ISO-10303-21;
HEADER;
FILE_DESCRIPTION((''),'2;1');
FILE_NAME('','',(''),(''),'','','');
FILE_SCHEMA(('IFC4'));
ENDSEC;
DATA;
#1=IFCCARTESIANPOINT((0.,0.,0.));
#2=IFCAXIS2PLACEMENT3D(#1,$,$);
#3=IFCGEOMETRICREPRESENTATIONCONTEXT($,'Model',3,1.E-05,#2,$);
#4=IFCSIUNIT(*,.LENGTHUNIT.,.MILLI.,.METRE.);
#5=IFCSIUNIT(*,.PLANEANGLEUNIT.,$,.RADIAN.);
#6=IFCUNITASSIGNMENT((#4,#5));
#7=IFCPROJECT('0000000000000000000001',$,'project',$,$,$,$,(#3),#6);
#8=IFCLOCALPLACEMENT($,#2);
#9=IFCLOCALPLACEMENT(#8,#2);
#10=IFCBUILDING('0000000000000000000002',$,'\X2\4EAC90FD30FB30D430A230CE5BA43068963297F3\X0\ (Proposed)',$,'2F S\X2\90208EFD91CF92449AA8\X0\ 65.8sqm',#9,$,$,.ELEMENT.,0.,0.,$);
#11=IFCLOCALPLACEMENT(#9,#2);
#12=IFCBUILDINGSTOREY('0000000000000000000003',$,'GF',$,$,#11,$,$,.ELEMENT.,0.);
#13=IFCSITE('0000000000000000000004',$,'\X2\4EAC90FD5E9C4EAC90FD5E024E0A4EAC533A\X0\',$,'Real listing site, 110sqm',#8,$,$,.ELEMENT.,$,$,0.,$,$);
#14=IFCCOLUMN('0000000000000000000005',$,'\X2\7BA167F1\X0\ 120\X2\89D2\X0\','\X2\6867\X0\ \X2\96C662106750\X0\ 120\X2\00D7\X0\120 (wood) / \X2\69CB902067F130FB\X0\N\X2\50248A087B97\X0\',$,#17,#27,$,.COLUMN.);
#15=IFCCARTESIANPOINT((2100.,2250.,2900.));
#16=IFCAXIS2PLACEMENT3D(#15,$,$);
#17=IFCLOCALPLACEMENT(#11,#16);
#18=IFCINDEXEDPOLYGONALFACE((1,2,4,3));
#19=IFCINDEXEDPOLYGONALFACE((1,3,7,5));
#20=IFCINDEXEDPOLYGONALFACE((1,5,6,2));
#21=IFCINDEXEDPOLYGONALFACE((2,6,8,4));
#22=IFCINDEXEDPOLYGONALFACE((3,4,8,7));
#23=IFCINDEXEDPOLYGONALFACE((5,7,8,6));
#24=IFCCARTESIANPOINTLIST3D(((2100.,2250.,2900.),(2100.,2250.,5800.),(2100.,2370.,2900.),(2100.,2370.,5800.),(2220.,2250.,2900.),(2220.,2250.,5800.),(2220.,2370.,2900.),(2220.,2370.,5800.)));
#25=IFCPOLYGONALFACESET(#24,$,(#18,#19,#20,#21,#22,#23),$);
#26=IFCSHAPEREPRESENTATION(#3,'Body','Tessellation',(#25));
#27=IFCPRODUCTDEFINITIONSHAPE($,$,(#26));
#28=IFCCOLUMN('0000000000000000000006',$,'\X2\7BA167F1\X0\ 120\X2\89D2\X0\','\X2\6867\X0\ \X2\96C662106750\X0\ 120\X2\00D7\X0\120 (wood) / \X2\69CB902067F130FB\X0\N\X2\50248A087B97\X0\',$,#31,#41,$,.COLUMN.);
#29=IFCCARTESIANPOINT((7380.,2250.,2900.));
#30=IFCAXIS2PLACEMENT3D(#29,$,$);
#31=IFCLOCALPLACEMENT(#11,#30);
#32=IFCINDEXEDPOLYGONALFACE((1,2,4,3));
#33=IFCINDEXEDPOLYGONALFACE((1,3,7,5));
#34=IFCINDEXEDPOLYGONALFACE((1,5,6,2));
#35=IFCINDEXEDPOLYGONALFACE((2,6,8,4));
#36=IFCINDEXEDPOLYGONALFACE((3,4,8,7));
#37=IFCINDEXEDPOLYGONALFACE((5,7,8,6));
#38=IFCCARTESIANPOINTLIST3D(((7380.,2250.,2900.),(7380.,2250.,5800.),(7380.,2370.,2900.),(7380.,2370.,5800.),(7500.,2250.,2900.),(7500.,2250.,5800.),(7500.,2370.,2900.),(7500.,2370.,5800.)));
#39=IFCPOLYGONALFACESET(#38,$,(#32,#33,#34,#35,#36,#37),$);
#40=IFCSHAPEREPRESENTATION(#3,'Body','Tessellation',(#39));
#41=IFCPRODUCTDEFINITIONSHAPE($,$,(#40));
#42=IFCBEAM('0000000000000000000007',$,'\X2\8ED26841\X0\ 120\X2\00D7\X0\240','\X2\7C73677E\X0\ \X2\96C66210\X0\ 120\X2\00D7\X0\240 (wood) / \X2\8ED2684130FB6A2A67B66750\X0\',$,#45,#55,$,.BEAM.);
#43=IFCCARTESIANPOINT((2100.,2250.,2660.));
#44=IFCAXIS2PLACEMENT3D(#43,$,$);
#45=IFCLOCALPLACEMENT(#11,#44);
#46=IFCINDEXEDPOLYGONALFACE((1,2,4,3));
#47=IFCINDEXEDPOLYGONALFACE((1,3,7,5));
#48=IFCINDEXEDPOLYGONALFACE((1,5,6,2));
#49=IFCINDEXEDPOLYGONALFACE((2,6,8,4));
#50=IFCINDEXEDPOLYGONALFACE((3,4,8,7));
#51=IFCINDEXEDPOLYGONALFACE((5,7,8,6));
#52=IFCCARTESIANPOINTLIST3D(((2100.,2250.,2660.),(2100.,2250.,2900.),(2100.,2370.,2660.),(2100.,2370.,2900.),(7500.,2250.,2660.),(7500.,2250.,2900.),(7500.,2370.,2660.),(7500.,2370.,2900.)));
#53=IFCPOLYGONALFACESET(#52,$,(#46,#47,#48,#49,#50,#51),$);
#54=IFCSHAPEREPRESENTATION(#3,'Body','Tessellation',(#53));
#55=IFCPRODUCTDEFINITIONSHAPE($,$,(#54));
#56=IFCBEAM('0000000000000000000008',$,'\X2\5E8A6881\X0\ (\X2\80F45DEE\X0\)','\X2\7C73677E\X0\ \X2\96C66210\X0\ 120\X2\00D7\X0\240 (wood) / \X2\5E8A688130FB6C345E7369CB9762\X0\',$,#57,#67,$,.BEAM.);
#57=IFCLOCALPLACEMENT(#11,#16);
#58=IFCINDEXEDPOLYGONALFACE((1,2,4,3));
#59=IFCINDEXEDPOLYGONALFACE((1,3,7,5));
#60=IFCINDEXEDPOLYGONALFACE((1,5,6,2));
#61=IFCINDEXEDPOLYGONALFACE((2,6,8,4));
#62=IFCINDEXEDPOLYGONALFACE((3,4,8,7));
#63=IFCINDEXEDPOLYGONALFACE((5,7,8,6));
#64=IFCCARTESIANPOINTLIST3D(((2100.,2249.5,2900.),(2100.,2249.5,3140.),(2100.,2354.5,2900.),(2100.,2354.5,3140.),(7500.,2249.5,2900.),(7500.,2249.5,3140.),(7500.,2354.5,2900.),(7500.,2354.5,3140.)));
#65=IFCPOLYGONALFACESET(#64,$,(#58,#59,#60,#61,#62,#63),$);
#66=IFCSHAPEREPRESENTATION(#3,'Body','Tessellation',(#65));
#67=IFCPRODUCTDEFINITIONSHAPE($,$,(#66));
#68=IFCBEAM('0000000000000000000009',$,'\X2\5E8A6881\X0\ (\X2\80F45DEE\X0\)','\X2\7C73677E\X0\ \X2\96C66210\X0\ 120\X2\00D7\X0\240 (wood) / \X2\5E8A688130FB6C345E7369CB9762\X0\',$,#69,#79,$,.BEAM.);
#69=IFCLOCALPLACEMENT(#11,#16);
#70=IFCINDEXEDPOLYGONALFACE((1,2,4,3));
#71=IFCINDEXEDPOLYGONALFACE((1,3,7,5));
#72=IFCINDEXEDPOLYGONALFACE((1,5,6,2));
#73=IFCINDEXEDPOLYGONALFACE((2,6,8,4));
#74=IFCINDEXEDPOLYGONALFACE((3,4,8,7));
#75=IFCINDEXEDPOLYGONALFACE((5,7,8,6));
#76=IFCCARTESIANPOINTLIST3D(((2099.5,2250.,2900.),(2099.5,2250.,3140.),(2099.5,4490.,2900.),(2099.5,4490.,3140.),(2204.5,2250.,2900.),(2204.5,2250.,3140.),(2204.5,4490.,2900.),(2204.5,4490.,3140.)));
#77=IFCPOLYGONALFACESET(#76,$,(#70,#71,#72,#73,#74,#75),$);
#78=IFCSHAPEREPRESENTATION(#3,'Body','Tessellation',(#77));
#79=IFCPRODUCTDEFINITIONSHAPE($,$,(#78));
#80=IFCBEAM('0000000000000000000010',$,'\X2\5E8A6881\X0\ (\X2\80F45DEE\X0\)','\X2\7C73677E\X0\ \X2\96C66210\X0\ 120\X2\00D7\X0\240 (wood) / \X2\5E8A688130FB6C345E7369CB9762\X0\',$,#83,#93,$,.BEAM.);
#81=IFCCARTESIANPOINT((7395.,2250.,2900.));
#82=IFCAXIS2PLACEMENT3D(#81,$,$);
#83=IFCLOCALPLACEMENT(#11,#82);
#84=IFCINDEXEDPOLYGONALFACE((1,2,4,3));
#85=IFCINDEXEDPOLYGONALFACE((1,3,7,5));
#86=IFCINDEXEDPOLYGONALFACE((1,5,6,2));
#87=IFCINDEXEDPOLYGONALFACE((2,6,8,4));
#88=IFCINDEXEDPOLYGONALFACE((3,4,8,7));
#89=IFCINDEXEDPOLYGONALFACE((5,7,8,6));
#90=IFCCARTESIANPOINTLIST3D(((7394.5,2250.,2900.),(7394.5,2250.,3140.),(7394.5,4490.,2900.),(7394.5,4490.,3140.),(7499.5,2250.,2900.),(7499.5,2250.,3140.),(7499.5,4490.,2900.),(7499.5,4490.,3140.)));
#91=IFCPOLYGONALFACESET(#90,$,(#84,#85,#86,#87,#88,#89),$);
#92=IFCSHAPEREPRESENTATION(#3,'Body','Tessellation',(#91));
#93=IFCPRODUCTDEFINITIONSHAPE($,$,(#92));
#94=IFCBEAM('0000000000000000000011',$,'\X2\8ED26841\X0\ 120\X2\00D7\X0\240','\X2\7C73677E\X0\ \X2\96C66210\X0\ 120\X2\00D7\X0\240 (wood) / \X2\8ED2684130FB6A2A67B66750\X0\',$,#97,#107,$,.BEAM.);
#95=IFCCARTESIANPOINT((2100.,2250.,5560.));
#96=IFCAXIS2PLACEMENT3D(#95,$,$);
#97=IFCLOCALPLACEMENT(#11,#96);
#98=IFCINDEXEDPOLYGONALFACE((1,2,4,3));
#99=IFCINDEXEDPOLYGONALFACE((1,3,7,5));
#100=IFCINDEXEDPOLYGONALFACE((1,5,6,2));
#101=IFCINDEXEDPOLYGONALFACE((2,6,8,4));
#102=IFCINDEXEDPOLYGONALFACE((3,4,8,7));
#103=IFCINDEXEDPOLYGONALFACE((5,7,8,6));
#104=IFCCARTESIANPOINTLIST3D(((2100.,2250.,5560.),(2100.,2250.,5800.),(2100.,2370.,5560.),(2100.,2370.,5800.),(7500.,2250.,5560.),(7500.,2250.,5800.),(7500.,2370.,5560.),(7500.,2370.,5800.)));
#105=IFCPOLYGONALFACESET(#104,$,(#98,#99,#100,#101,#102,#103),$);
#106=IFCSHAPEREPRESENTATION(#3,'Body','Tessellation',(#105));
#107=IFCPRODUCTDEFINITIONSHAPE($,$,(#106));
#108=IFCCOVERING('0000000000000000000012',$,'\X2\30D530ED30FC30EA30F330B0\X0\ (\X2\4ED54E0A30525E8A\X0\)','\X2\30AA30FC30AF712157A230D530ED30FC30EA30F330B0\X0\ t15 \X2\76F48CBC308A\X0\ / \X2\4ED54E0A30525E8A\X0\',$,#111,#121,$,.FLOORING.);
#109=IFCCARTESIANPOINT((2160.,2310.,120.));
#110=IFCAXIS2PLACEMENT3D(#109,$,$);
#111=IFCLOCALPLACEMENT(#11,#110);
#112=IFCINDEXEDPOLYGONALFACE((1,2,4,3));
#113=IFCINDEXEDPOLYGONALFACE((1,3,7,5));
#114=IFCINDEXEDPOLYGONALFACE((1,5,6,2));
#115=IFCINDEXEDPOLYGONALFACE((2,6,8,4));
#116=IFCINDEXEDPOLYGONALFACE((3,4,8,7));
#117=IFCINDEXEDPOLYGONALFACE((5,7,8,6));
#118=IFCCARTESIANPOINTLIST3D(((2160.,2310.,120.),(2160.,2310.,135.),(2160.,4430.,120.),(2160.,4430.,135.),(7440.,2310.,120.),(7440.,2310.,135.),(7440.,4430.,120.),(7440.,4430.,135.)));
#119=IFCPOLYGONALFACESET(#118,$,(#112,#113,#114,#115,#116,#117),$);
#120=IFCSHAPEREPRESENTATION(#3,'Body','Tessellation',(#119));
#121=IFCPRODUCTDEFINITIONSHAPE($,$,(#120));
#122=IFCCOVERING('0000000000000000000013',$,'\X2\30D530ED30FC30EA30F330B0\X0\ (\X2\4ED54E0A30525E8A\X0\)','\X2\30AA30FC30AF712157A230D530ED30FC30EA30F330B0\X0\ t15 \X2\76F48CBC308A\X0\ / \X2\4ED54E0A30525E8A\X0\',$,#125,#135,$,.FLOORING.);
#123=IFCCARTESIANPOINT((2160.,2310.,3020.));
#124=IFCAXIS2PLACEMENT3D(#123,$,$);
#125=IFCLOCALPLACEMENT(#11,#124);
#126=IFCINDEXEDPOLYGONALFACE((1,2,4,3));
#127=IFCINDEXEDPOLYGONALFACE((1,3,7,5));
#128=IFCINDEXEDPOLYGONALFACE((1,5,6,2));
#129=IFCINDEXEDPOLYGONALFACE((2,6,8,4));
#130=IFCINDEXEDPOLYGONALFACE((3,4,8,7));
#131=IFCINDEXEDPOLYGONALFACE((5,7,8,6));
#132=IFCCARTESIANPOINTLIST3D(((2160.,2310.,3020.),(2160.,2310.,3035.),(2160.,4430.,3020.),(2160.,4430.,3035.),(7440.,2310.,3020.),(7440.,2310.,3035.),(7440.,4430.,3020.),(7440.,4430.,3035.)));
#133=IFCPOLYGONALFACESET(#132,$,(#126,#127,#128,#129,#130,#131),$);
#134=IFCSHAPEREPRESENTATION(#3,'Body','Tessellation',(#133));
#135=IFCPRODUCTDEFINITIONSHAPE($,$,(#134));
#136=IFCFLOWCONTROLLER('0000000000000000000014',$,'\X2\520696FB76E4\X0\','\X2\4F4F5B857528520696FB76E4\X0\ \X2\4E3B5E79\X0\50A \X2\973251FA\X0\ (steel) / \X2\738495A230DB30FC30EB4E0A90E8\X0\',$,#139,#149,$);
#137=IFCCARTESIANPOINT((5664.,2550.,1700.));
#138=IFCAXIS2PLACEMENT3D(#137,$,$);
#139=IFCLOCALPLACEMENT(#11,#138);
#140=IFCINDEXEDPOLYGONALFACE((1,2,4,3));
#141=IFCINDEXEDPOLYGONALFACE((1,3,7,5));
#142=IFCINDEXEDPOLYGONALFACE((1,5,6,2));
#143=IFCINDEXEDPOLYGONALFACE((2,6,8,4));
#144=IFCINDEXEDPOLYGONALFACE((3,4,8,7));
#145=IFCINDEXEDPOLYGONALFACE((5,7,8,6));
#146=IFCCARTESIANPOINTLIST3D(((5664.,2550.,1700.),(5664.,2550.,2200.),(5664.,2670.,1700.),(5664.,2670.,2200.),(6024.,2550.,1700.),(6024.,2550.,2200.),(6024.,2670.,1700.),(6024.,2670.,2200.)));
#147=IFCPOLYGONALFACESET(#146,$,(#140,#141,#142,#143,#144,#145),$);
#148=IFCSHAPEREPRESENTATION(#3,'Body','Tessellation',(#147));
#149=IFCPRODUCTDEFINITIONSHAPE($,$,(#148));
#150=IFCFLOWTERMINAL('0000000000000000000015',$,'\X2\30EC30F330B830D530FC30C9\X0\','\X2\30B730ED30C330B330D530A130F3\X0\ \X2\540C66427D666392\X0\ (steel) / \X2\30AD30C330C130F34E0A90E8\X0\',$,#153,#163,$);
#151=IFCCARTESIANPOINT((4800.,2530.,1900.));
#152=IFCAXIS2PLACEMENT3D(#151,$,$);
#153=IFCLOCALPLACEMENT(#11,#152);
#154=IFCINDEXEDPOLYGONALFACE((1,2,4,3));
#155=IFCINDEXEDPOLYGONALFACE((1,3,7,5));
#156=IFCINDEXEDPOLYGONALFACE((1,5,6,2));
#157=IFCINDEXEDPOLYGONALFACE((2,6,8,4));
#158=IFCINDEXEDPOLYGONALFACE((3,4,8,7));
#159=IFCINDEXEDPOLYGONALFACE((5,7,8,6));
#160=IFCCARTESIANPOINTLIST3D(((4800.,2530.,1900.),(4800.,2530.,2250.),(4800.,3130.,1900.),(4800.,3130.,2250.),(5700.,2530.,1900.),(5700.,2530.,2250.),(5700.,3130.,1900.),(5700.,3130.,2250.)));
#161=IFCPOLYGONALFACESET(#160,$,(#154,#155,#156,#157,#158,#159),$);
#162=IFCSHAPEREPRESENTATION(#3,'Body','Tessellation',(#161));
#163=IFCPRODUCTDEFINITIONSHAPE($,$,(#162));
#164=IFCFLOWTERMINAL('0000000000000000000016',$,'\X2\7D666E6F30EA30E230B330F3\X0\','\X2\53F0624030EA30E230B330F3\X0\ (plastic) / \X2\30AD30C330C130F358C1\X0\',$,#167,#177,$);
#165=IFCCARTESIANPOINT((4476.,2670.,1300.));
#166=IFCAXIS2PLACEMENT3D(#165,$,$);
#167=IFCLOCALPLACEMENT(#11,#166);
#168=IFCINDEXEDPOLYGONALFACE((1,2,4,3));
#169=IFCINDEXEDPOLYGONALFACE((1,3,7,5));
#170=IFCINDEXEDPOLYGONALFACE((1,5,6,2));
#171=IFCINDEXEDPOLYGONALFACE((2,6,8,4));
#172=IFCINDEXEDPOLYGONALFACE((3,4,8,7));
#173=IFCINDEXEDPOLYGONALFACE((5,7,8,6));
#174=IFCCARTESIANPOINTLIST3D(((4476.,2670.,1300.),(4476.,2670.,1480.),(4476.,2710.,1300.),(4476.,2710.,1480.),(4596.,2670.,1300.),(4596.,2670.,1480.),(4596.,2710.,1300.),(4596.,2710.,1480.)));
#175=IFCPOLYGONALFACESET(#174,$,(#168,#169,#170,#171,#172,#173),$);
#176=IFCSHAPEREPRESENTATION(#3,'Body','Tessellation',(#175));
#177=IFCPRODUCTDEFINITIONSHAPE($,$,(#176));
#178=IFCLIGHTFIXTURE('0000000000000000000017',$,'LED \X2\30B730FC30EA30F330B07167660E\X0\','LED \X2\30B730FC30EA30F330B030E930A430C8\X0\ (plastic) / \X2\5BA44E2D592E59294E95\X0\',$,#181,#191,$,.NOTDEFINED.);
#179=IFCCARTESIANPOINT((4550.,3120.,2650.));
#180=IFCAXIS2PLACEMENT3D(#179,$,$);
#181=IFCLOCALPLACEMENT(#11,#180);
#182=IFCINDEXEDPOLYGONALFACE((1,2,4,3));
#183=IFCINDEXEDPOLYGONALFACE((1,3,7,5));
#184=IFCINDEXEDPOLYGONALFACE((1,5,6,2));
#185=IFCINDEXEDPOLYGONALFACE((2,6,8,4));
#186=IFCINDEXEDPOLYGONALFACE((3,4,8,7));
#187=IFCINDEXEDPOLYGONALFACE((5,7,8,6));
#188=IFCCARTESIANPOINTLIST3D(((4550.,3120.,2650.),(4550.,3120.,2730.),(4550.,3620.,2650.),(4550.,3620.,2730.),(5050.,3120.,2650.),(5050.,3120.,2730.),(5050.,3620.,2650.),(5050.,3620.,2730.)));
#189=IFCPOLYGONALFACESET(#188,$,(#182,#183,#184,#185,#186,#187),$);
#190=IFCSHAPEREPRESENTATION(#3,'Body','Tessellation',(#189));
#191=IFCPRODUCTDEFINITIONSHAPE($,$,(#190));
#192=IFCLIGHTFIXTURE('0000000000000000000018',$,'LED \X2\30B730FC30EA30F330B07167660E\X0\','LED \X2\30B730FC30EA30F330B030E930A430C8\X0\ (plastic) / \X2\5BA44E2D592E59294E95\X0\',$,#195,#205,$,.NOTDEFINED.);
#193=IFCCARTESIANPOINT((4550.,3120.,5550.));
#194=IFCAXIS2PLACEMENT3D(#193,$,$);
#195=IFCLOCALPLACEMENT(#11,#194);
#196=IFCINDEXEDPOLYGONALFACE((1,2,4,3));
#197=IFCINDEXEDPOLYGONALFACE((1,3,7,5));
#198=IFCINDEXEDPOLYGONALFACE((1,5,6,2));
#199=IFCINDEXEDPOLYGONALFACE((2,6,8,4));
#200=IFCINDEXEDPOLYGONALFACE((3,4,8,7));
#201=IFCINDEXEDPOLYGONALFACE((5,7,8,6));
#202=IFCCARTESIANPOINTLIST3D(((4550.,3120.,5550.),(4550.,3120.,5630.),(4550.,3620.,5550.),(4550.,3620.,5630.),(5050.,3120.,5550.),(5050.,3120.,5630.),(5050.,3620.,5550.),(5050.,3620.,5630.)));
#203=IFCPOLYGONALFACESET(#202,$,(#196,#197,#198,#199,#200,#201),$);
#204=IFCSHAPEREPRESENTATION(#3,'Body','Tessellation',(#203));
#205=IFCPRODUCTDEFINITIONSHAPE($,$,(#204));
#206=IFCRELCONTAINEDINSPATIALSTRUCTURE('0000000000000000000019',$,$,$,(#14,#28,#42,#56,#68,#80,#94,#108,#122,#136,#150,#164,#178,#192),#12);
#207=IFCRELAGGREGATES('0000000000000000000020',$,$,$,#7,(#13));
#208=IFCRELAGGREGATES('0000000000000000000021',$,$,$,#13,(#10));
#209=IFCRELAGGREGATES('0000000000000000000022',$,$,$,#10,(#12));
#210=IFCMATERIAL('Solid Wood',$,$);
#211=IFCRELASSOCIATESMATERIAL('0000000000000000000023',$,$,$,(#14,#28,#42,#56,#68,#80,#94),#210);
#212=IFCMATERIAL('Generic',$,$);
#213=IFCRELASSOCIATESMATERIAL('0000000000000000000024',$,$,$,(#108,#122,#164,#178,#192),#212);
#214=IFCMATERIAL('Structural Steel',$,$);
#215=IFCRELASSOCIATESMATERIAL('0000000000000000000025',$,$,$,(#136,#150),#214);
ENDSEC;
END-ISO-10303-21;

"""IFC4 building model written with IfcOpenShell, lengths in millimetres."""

from ifc_helpers import new_model, si_unit, frame, frame_2d, origin, place, context, project, spatial, rectangle, extrude, material, element, save


model = new_model("IFC4")

# Units and contexts
model_context = context("Model", 3, precision=1e-05, world=origin())
ifc_project = project(units=[si_unit("LENGTHUNIT", "METRE", prefix="MILLI"), si_unit("PLANEANGLEUNIT", "RADIAN")], contexts=[model_context])

# Site, building, storey
site_placement = place(None, origin())
site = spatial("IfcSite", under=ifc_project, at=site_placement, Name="京都府京都市上京区", ObjectType="Real listing site, 110sqm", CompositionType="ELEMENT", RefElevation=0.0)
building_placement = place(site_placement, origin())
building = spatial("IfcBuilding", under=site, at=building_placement, Name="京都・ピアノ室と防音 (Proposed)", ObjectType="2F S造軽量鉄骨 65.8sqm", CompositionType="ELEMENT", ElevationOfRefHeight=0.0, ElevationOfTerrain=0.0)
storey_placement = place(building_placement, origin())
storey = spatial("IfcBuildingStorey", under=building, at=storey_placement, Name="GF", CompositionType="ELEMENT", Elevation=0.0)

# Columns
ifc_material_1 = material(Name="Solid Wood")
column_1_placement = place(storey_placement, frame((2100.0, 2250.0, 2900.0)))
element("IfcColumn", 1, at=column_1_placement, inside=storey, material=ifc_material_1, Name="管柱 120角", Description="桧 集成材 120×120 (wood) / 構造柱・N値計算", PredefinedType="COLUMN", context=model_context, shape_type="SweptSolid", body=[
    extrude(rectangle(XDim=120.0, YDim=120.0, at=frame_2d((60.0, 60.0))), frame((2100.0, 2250.0, 2900.0)), (0.0, 0.0, 1.0), 2900.0),
])
column_2_placement = place(storey_placement, frame((7380.0, 2250.0, 2900.0)))
element("IfcColumn", 2, at=column_2_placement, inside=storey, material=ifc_material_1, Name="管柱 120角", Description="桧 集成材 120×120 (wood) / 構造柱・N値計算", PredefinedType="COLUMN", context=model_context, shape_type="SweptSolid", body=[
    extrude(rectangle(XDim=120.0, YDim=120.0, at=frame_2d((60.0, 60.0))), frame((7380.0, 2250.0, 2900.0)), (0.0, 0.0, 1.0), 2900.0),
])

# Beams
beam_1_placement = place(storey_placement, frame((2100.0, 2250.0, 2660.0)))
element("IfcBeam", 3, at=beam_1_placement, inside=storey, material=ifc_material_1, Name="軒桁 120×240", Description="米松 集成 120×240 (wood) / 軒桁・横架材", PredefinedType="BEAM", context=model_context, shape_type="SweptSolid", body=[
    extrude(rectangle(XDim=5400.0, YDim=120.0, at=frame_2d((2700.0, 60.0))), frame((2100.0, 2250.0, 2660.0)), (0.0, 0.0, 1.0), 240.0),
])
beam_2_placement = place(storey_placement, frame((2100.0, 2250.0, 2900.0)))
element("IfcBeam", 4, at=beam_2_placement, inside=storey, material=ifc_material_1, Name="床梁 (胴差)", Description="米松 集成 120×240 (wood) / 床梁・水平構面", PredefinedType="BEAM", context=model_context, shape_type="SweptSolid", body=[
    extrude(rectangle(XDim=5400.0, YDim=105.0, at=frame_2d((2700.0, 52.0))), frame((2100.0, 2250.0, 2900.0)), (0.0, 0.0, 1.0), 240.0),
])
beam_3_placement = place(storey_placement, frame((2100.0, 2250.0, 2900.0)))
element("IfcBeam", 5, at=beam_3_placement, inside=storey, material=ifc_material_1, Name="床梁 (胴差)", Description="米松 集成 120×240 (wood) / 床梁・水平構面", PredefinedType="BEAM", context=model_context, shape_type="SweptSolid", body=[
    extrude(rectangle(XDim=105.0, YDim=2240.0, at=frame_2d((52.0, 1120.0))), frame((2100.0, 2250.0, 2900.0)), (0.0, 0.0, 1.0), 240.0),
])
beam_4_placement = place(storey_placement, frame((7395.0, 2250.0, 2900.0)))
element("IfcBeam", 6, at=beam_4_placement, inside=storey, material=ifc_material_1, Name="床梁 (胴差)", Description="米松 集成 120×240 (wood) / 床梁・水平構面", PredefinedType="BEAM", context=model_context, shape_type="SweptSolid", body=[
    extrude(rectangle(XDim=105.0, YDim=2240.0, at=frame_2d((52.0, 1120.0))), frame((7395.0, 2250.0, 2900.0)), (0.0, 0.0, 1.0), 240.0),
])
beam_5_placement = place(storey_placement, frame((2100.0, 2250.0, 5560.0)))
element("IfcBeam", 7, at=beam_5_placement, inside=storey, material=ifc_material_1, Name="軒桁 120×240", Description="米松 集成 120×240 (wood) / 軒桁・横架材", PredefinedType="BEAM", context=model_context, shape_type="SweptSolid", body=[
    extrude(rectangle(XDim=5400.0, YDim=120.0, at=frame_2d((2700.0, 60.0))), frame((2100.0, 2250.0, 5560.0)), (0.0, 0.0, 1.0), 240.0),
])

# Coverings
ifc_material_2 = material(Name="Generic")
covering_1_placement = place(storey_placement, frame((2160.0, 2310.0, 120.0)))
element("IfcCovering", 8, at=covering_1_placement, inside=storey, material=ifc_material_2, Name="フローリング (仕上げ床)", Description="オーク無垢フローリング t15 直貼り / 仕上げ床", PredefinedType="FLOORING", context=model_context, shape_type="SweptSolid", body=[
    extrude(rectangle(XDim=5280.0, YDim=2120.0, at=frame_2d((2640.0, 1060.0))), frame((2160.0, 2310.0, 120.0)), (0.0, 0.0, 1.0), 15.0),
])
covering_2_placement = place(storey_placement, frame((2160.0, 2310.0, 3020.0)))
element("IfcCovering", 9, at=covering_2_placement, inside=storey, material=ifc_material_2, Name="フローリング (仕上げ床)", Description="オーク無垢フローリング t15 直貼り / 仕上げ床", PredefinedType="FLOORING", context=model_context, shape_type="SweptSolid", body=[
    extrude(rectangle(XDim=5280.0, YDim=2120.0, at=frame_2d((2640.0, 1060.0))), frame((2160.0, 2310.0, 3020.0)), (0.0, 0.0, 1.0), 15.0),
])

# Flow controller
ifc_material_3 = material(Name="Structural Steel")
flow_controller_placement = place(storey_placement, frame((5664.0, 2550.0, 1700.0)))
element("IfcFlowController", 10, at=flow_controller_placement, inside=storey, material=ifc_material_3, Name="分電盤", Description="住宅用分電盤 主幹50A 露出 (steel) / 玄関ホール上部", context=model_context, shape_type="SweptSolid", body=[
    extrude(rectangle(XDim=360.0, YDim=120.0, at=frame_2d((180.0, 60.0))), frame((5664.0, 2550.0, 1700.0)), (0.0, 0.0, 1.0), 500.0),
])

# Flow terminals
flow_terminal_1_placement = place(storey_placement, frame((4800.0, 2530.0, 1900.0)))
element("IfcFlowTerminal", 11, at=flow_terminal_1_placement, inside=storey, material=ifc_material_3, Name="レンジフード", Description="シロッコファン 同時給排 (steel) / キッチン上部", context=model_context, shape_type="SweptSolid", body=[
    extrude(rectangle(XDim=900.0, YDim=600.0, at=frame_2d((450.0, 300.0))), frame((4800.0, 2530.0, 1900.0)), (0.0, 0.0, 1.0), 350.0),
])
flow_terminal_2_placement = place(storey_placement, frame((4476.0, 2670.0, 1300.0)))
element("IfcFlowTerminal", 12, at=flow_terminal_2_placement, inside=storey, material=ifc_material_2, Name="給湯リモコン", Description="台所リモコン (plastic) / キッチン壁", context=model_context, shape_type="SweptSolid", body=[
    extrude(rectangle(XDim=120.0, YDim=40.0, at=frame_2d((60.0, 20.0))), frame((4476.0, 2670.0, 1300.0)), (0.0, 0.0, 1.0), 180.0),
])

# Light fixtures
light_fixture_1_placement = place(storey_placement, frame((4550.0, 3120.0, 2650.0)))
element("IfcLightFixture", 13, at=light_fixture_1_placement, inside=storey, material=ifc_material_2, Name="LED シーリング照明", Description="LED シーリングライト (plastic) / 室中央天井", PredefinedType="NOTDEFINED", context=model_context, shape_type="SweptSolid", body=[
    extrude(rectangle(XDim=500.0, YDim=500.0, at=frame_2d((250.0, 250.0))), frame((4550.0, 3120.0, 2650.0)), (0.0, 0.0, 1.0), 80.0),
])
light_fixture_2_placement = place(storey_placement, frame((4550.0, 3120.0, 5550.0)))
element("IfcLightFixture", 14, at=light_fixture_2_placement, inside=storey, material=ifc_material_2, Name="LED シーリング照明", Description="LED シーリングライト (plastic) / 室中央天井", PredefinedType="NOTDEFINED", context=model_context, shape_type="SweptSolid", body=[
    extrude(rectangle(XDim=500.0, YDim=500.0, at=frame_2d((250.0, 250.0))), frame((4550.0, 3120.0, 5550.0)), (0.0, 0.0, 1.0), 80.0),
])

save(model, "model.ifc")
